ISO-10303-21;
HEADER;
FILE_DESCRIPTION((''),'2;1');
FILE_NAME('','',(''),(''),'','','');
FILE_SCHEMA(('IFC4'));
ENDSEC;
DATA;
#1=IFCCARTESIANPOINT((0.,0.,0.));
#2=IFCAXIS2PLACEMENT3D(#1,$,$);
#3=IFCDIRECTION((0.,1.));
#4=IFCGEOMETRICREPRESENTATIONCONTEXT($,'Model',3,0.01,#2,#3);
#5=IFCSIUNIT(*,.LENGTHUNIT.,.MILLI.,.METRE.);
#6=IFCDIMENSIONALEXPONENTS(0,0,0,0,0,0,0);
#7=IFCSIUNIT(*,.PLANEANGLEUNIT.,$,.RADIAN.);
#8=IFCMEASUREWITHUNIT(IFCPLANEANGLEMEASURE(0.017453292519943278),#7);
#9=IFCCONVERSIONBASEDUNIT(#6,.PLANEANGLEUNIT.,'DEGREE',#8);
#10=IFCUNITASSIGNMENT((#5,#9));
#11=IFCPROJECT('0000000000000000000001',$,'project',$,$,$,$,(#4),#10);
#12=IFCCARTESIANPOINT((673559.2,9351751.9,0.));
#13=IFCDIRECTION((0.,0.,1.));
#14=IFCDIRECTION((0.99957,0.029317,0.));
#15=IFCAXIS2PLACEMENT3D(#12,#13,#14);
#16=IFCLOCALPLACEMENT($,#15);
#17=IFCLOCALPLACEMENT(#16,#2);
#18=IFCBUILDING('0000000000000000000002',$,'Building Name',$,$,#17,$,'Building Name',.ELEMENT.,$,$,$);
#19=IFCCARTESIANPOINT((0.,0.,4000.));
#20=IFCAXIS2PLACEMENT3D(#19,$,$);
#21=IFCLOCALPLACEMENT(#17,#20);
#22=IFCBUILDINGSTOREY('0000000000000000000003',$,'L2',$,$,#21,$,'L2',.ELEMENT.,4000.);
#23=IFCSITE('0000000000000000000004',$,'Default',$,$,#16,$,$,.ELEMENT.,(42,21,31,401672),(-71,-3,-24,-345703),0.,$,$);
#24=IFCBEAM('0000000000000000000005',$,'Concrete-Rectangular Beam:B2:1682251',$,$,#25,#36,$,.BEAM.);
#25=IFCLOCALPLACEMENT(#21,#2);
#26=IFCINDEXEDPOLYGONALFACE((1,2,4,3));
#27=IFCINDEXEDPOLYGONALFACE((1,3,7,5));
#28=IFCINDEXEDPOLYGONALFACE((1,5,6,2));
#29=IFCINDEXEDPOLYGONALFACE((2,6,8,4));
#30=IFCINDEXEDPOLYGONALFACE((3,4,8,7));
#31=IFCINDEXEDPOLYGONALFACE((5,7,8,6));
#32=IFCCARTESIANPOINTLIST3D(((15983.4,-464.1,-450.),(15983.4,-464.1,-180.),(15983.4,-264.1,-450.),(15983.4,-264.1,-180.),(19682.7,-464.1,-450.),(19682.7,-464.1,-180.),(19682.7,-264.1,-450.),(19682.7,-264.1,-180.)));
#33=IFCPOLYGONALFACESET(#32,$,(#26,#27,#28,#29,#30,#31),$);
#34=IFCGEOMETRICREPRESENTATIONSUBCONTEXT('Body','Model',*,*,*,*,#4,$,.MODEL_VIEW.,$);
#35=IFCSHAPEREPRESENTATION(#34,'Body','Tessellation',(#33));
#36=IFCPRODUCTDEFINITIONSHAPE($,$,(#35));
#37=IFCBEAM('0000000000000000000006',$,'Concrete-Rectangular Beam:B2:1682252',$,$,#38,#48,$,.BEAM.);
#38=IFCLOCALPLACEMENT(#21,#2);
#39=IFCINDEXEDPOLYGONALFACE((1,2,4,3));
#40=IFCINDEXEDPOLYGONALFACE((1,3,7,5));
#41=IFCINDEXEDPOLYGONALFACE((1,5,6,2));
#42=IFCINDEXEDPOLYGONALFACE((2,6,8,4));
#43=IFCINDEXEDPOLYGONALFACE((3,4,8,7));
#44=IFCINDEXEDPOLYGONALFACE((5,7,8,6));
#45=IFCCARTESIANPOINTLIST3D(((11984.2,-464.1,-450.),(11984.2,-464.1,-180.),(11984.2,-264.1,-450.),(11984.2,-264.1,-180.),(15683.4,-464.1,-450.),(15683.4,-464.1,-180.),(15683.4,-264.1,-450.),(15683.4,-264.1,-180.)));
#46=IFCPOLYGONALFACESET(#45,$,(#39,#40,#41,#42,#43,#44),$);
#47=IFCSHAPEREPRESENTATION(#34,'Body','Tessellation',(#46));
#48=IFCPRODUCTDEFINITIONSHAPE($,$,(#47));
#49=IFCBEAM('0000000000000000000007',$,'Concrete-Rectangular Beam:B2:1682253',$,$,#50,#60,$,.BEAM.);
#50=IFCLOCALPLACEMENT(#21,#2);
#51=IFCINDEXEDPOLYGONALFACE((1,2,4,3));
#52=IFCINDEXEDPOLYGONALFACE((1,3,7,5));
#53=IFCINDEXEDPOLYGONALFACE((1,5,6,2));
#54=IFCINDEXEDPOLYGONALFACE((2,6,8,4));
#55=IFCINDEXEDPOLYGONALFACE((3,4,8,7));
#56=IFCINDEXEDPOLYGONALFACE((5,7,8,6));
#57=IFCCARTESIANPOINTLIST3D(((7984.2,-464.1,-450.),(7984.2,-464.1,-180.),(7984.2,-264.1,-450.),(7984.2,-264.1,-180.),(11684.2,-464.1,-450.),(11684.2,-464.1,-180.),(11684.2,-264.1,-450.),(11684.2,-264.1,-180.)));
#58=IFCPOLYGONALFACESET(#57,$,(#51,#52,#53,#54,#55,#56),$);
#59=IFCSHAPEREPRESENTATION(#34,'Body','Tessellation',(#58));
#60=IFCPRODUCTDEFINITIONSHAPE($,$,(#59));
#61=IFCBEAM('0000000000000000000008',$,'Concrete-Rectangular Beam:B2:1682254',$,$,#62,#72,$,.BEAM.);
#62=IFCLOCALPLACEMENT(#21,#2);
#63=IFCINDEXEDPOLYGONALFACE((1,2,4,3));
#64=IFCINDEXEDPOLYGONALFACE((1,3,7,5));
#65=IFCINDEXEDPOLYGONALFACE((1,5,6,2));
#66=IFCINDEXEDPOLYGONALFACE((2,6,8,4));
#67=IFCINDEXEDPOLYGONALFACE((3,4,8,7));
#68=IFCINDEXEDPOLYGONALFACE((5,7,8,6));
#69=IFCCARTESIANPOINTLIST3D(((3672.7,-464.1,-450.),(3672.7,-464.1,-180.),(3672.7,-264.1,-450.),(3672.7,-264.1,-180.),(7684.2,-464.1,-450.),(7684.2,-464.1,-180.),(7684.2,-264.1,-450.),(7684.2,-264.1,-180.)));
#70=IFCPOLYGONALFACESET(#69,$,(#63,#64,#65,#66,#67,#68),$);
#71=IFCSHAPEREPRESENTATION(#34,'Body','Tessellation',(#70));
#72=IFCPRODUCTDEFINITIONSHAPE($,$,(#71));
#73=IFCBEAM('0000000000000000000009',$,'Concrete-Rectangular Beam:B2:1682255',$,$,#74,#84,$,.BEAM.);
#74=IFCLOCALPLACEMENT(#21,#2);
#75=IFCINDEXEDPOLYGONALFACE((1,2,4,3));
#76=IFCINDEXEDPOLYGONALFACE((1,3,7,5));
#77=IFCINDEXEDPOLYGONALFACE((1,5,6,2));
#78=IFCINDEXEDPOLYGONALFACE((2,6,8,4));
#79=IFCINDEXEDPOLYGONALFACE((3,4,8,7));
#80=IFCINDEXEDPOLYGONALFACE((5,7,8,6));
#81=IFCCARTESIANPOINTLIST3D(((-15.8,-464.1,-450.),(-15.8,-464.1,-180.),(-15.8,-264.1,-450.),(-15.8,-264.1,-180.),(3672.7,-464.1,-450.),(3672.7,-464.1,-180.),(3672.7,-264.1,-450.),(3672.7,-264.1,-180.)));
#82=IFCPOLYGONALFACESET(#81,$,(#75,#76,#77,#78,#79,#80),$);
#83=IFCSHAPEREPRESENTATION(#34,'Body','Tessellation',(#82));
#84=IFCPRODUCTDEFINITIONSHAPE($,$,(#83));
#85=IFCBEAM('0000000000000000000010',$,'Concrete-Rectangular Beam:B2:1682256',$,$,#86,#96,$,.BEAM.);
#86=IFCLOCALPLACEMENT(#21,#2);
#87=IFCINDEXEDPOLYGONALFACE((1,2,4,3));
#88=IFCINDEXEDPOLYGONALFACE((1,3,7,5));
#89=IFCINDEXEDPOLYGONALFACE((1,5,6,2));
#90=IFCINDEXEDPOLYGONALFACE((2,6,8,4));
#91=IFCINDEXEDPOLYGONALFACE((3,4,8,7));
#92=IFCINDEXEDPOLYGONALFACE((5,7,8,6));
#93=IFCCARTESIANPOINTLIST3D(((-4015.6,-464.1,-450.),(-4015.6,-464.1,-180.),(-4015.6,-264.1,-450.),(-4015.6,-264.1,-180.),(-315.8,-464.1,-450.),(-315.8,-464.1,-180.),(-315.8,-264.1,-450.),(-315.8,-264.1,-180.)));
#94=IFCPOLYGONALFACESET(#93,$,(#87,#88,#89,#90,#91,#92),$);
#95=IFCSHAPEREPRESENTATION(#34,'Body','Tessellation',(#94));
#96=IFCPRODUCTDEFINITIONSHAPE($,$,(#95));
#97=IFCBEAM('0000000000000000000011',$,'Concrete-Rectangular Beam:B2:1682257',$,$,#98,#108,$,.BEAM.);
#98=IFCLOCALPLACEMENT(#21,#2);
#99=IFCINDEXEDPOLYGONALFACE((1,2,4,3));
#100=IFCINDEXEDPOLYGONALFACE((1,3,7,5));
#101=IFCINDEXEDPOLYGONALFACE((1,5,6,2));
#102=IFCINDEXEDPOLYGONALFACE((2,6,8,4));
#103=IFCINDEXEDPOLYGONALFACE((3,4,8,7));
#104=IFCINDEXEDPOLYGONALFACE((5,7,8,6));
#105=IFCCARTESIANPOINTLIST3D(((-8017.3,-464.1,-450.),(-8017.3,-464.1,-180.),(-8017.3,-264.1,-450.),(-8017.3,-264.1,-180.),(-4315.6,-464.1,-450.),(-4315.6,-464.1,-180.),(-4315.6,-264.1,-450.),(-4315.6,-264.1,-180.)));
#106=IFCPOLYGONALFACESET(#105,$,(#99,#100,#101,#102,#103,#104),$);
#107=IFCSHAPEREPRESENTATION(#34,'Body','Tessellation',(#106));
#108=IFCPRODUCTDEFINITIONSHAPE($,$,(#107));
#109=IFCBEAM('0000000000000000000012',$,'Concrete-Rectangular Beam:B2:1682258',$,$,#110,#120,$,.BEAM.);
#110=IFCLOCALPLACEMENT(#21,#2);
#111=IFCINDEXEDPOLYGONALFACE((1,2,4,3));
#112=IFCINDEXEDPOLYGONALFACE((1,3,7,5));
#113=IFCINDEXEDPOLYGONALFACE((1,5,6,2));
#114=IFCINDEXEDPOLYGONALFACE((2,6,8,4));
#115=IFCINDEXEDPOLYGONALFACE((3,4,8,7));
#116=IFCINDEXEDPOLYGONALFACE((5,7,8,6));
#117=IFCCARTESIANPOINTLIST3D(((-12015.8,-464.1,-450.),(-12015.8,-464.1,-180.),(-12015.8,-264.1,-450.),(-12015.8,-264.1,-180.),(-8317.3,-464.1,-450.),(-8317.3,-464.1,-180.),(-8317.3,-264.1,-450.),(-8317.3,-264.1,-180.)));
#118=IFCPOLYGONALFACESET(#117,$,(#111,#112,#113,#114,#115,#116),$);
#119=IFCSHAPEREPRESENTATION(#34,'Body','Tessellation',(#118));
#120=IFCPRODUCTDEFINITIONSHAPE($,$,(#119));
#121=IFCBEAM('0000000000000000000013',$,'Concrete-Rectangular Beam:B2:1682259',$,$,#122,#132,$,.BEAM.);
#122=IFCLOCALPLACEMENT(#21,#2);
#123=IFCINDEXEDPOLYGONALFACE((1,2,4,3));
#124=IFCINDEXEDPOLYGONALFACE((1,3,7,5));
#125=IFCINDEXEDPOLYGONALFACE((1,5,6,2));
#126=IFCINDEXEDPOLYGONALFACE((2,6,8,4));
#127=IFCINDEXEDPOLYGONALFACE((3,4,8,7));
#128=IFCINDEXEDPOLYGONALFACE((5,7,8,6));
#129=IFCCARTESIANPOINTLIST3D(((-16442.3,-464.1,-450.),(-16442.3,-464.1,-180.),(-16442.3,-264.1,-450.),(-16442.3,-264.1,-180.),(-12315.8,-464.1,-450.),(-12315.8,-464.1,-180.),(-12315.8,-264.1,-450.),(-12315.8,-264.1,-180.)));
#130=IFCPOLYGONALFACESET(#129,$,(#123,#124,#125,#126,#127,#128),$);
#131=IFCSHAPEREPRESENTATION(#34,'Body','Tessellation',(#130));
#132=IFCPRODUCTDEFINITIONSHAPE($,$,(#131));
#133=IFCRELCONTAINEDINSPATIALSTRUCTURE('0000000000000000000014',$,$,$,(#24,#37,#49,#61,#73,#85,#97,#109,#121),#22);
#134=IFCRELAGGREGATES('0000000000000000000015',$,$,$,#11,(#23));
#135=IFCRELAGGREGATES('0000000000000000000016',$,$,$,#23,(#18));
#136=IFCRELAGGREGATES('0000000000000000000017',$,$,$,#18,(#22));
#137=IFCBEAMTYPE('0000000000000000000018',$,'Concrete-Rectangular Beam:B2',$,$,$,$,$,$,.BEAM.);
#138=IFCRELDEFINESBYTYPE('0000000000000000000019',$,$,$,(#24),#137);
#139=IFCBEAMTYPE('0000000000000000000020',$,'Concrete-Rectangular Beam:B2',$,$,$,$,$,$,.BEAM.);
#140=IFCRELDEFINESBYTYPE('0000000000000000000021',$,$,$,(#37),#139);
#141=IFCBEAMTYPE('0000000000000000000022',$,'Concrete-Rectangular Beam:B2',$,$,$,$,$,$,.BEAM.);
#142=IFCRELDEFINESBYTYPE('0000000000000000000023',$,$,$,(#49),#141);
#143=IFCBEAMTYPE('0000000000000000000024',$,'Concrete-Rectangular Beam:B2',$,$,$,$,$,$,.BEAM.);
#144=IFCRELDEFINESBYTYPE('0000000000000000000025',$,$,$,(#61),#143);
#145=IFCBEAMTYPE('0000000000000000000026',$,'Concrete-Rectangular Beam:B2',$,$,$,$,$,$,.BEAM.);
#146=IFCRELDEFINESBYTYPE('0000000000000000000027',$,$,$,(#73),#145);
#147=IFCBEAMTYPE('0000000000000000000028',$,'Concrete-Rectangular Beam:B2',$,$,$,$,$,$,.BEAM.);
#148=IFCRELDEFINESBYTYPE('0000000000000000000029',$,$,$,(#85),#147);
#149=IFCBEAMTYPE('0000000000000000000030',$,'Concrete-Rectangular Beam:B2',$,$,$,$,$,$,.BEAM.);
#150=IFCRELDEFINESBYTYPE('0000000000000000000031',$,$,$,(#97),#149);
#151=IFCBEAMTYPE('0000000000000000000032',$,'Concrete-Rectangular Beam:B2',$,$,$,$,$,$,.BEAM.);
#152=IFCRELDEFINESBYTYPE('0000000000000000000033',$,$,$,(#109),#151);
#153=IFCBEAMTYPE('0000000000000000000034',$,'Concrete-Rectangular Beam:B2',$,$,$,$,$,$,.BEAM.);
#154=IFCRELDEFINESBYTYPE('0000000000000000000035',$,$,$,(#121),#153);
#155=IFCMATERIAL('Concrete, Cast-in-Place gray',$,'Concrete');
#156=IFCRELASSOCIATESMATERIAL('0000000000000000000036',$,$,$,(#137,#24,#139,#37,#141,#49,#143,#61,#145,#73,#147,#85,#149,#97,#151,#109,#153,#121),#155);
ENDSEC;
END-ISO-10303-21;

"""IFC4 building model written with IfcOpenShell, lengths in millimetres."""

from ifc_helpers import new_model, entity, si_unit, converted_unit, direction, frame, origin, place, context, subcontext, project, spatial, indexed_curve, outline, extrude, source, transform, mapped, material, type_object, type_shapes, element, save


model = new_model("IFC4")

# Units and contexts
model_context = context("Model", 3, precision=0.01, world=origin(), true_north=direction((0.0, 1.0)))
body_context = subcontext(model_context, "Body", "Model", "MODEL_VIEW")
ifc_project = project(units=[si_unit("LENGTHUNIT", "METRE", prefix="MILLI"), converted_unit("PLANEANGLEUNIT", "DEGREE", entity("IfcPlaneAngleMeasure", 0.017453292519943278), si_unit("PLANEANGLEUNIT", "RADIAN"), dimensions=[0, 0, 0, 0, 0, 0, 0])], contexts=[model_context])

# Site, building, storey
site_placement = place(None, frame((673559.2, 9351751.9, 0.0), z_axis=(0.0, 0.0, 1.0), x_axis=(0.99957, 0.029317, 0.0)))
site = spatial("IfcSite", under=ifc_project, at=site_placement, Name="Default", CompositionType="ELEMENT", RefLatitude=(42, 21, 31, 401672), RefLongitude=(-71, -3, -24, -345703), RefElevation=0.0)
building_placement = place(site_placement, origin())
building = spatial("IfcBuilding", under=site, at=building_placement, Name="Building Name", LongName="Building Name", CompositionType="ELEMENT")
storey_placement = place(building_placement, frame((0.0, 0.0, 4000.0)))
storey = spatial("IfcBuildingStorey", under=building, at=storey_placement, Name="L2", LongName="L2", CompositionType="ELEMENT", Elevation=4000.0)

# Beams
ifc_material = material(Name="Concrete, Cast-in-Place gray", Category="Concrete")
beam_type_1 = type_object("IfcBeamType", Name="Concrete-Rectangular Beam:B2", PredefinedType="BEAM", material=ifc_material)
shared_shape_1 = source(origin(), body_context, "Body", "SweptSolid", [
    extrude(outline(indexed_curve([(-135.0, -100.0), (135.0, -100.0), (135.0, 100.0), (-135.0, 100.0), (-135.0, -100.0)], self_intersect=False)), frame((19682.7, -364.1, 3685.0), z_axis=(-1.0, 0.0, 0.0), x_axis=(0.0, 0.0, -1.0)), (0.0, 0.0, 1.0), 3699.3),
])
type_shapes(beam_type_1, [shared_shape_1])
beam_1_placement = place(storey_placement, frame((0.0, 0.0, -4000.0)))
element("IfcBeam", 1, at=beam_1_placement, inside=storey, type_object=beam_type_1, material=ifc_material, Name="Concrete-Rectangular Beam:B2:1682251", PredefinedType="BEAM", context=body_context, shape_type="MappedRepresentation", body=[
    mapped(shared_shape_1, transform((0.0, 0.0, 0.0), scale=1.0)),
])
beam_type_2 = type_object("IfcBeamType", Name="Concrete-Rectangular Beam:B2", PredefinedType="BEAM", material=ifc_material)
shared_shape_2 = source(origin(), body_context, "Body", "SweptSolid", [
    extrude(outline(indexed_curve([(-135.0, -100.0), (135.0, -100.0), (135.0, 100.0), (-135.0, 100.0), (-135.0, -100.0)], self_intersect=False)), frame((11984.2, -364.1, 3685.0), z_axis=(1.0, 0.0, 0.0), x_axis=(0.0, 0.0, -1.0)), (0.0, 0.0, 1.0), 3699.3),
])
type_shapes(beam_type_2, [shared_shape_2])
beam_2_placement = place(storey_placement, frame((0.0, 0.0, -4000.0)))
element("IfcBeam", 2, at=beam_2_placement, inside=storey, type_object=beam_type_2, material=ifc_material, Name="Concrete-Rectangular Beam:B2:1682252", PredefinedType="BEAM", context=body_context, shape_type="MappedRepresentation", body=[
    mapped(shared_shape_2, transform((0.0, 0.0, 0.0), scale=1.0)),
])
beam_type_3 = type_object("IfcBeamType", Name="Concrete-Rectangular Beam:B2", PredefinedType="BEAM", material=ifc_material)
shared_shape_3 = source(origin(), body_context, "Body", "SweptSolid", [
    extrude(outline(indexed_curve([(-135.0, -100.0), (135.0, -100.0), (135.0, 100.0), (-135.0, 100.0), (-135.0, -100.0)], self_intersect=False)), frame((11684.2, -364.1, 3685.0), z_axis=(-1.0, 0.0, 0.0), x_axis=(0.0, 0.0, -1.0)), (0.0, 0.0, 1.0), 3700.0),
])
type_shapes(beam_type_3, [shared_shape_3])
beam_3_placement = place(storey_placement, frame((0.0, 0.0, -4000.0)))
element("IfcBeam", 3, at=beam_3_placement, inside=storey, type_object=beam_type_3, material=ifc_material, Name="Concrete-Rectangular Beam:B2:1682253", PredefinedType="BEAM", context=body_context, shape_type="MappedRepresentation", body=[
    mapped(shared_shape_3, transform((0.0, 0.0, 0.0), scale=1.0)),
])
beam_type_4 = type_object("IfcBeamType", Name="Concrete-Rectangular Beam:B2", PredefinedType="BEAM", material=ifc_material)
shared_shape_4 = source(origin(), body_context, "Body", "SweptSolid", [
    extrude(outline(indexed_curve([(-135.0, -100.0), (135.0, -100.0), (135.0, 100.0), (-135.0, 100.0), (-135.0, -100.0)], self_intersect=False)), frame((7684.2, -364.1, 3685.0), z_axis=(-1.0, 0.0, 0.0), x_axis=(0.0, 0.0, -1.0)), (0.0, 0.0, 1.0), 4011.4),
])
type_shapes(beam_type_4, [shared_shape_4])
beam_4_placement = place(storey_placement, frame((0.0, 0.0, -4000.0)))
element("IfcBeam", 4, at=beam_4_placement, inside=storey, type_object=beam_type_4, material=ifc_material, Name="Concrete-Rectangular Beam:B2:1682254", PredefinedType="BEAM", context=body_context, shape_type="MappedRepresentation", body=[
    mapped(shared_shape_4, transform((0.0, 0.0, 0.0), scale=1.0)),
])
beam_type_5 = type_object("IfcBeamType", Name="Concrete-Rectangular Beam:B2", PredefinedType="BEAM", material=ifc_material)
shared_shape_5 = source(origin(), body_context, "Body", "SweptSolid", [
    extrude(outline(indexed_curve([(-135.0, -100.0), (135.0, -100.0), (135.0, 100.0), (-135.0, 100.0), (-135.0, -100.0)], self_intersect=False)), frame((3672.7, -364.1, 3685.0), z_axis=(-1.0, 0.0, 0.0), x_axis=(0.0, 0.0, -1.0)), (0.0, 0.0, 1.0), 3688.6),
])
type_shapes(beam_type_5, [shared_shape_5])
beam_5_placement = place(storey_placement, frame((0.0, 0.0, -4000.0)))
element("IfcBeam", 5, at=beam_5_placement, inside=storey, type_object=beam_type_5, material=ifc_material, Name="Concrete-Rectangular Beam:B2:1682255", PredefinedType="BEAM", context=body_context, shape_type="MappedRepresentation", body=[
    mapped(shared_shape_5, transform((0.0, 0.0, 0.0), scale=1.0)),
])
beam_type_6 = type_object("IfcBeamType", Name="Concrete-Rectangular Beam:B2", PredefinedType="BEAM", material=ifc_material)
shared_shape_6 = source(origin(), body_context, "Body", "SweptSolid", [
    extrude(outline(indexed_curve([(-135.0, -100.0), (135.0, -100.0), (135.0, 100.0), (-135.0, 100.0), (-135.0, -100.0)], self_intersect=False)), frame((-315.8, -364.1, 3685.0), z_axis=(-1.0, 0.0, 0.0), x_axis=(0.0, 0.0, -1.0)), (0.0, 0.0, 1.0), 3699.7),
])
type_shapes(beam_type_6, [shared_shape_6])
beam_6_placement = place(storey_placement, frame((0.0, 0.0, -4000.0)))
element("IfcBeam", 6, at=beam_6_placement, inside=storey, type_object=beam_type_6, material=ifc_material, Name="Concrete-Rectangular Beam:B2:1682256", PredefinedType="BEAM", context=body_context, shape_type="MappedRepresentation", body=[
    mapped(shared_shape_6, transform((0.0, 0.0, 0.0), scale=1.0)),
])
beam_type_7 = type_object("IfcBeamType", Name="Concrete-Rectangular Beam:B2", PredefinedType="BEAM", material=ifc_material)
shared_shape_7 = source(origin(), body_context, "Body", "SweptSolid", [
    extrude(outline(indexed_curve([(-135.0, -100.0), (135.0, -100.0), (135.0, 100.0), (-135.0, 100.0), (-135.0, -100.0)], self_intersect=False)), frame((-4315.6, -364.1, 3685.0), z_axis=(-1.0, 0.0, 0.0), x_axis=(0.0, 0.0, -1.0)), (0.0, 0.0, 1.0), 3701.8),
])
type_shapes(beam_type_7, [shared_shape_7])
beam_7_placement = place(storey_placement, frame((0.0, 0.0, -4000.0)))
element("IfcBeam", 7, at=beam_7_placement, inside=storey, type_object=beam_type_7, material=ifc_material, Name="Concrete-Rectangular Beam:B2:1682257", PredefinedType="BEAM", context=body_context, shape_type="MappedRepresentation", body=[
    mapped(shared_shape_7, transform((0.0, 0.0, 0.0), scale=1.0)),
])
beam_type_8 = type_object("IfcBeamType", Name="Concrete-Rectangular Beam:B2", PredefinedType="BEAM", material=ifc_material)
shared_shape_8 = source(origin(), body_context, "Body", "SweptSolid", [
    extrude(outline(indexed_curve([(-135.0, -100.0), (135.0, -100.0), (135.0, 100.0), (-135.0, 100.0), (-135.0, -100.0)], self_intersect=False)), frame((-8317.3, -364.1, 3685.0), z_axis=(-1.0, 0.0, 0.0), x_axis=(0.0, 0.0, -1.0)), (0.0, 0.0, 1.0), 3698.5),
])
type_shapes(beam_type_8, [shared_shape_8])
beam_8_placement = place(storey_placement, frame((0.0, 0.0, -4000.0)))
element("IfcBeam", 8, at=beam_8_placement, inside=storey, type_object=beam_type_8, material=ifc_material, Name="Concrete-Rectangular Beam:B2:1682258", PredefinedType="BEAM", context=body_context, shape_type="MappedRepresentation", body=[
    mapped(shared_shape_8, transform((0.0, 0.0, 0.0), scale=1.0)),
])
beam_type_9 = type_object("IfcBeamType", Name="Concrete-Rectangular Beam:B2", PredefinedType="BEAM", material=ifc_material)
shared_shape_9 = source(origin(), body_context, "Body", "SweptSolid", [
    extrude(outline(indexed_curve([(-135.0, -100.0), (135.0, -100.0), (135.0, 100.0), (-135.0, 100.0), (-135.0, -100.0)], self_intersect=False)), frame((-12315.8, -364.1, 3685.0), z_axis=(-1.0, 0.0, 0.0), x_axis=(0.0, 0.0, -1.0)), (0.0, 0.0, 1.0), 4126.5),
])
type_shapes(beam_type_9, [shared_shape_9])
beam_9_placement = place(storey_placement, frame((0.0, 0.0, -4000.0)))
element("IfcBeam", 9, at=beam_9_placement, inside=storey, type_object=beam_type_9, material=ifc_material, Name="Concrete-Rectangular Beam:B2:1682259", PredefinedType="BEAM", context=body_context, shape_type="MappedRepresentation", body=[
    mapped(shared_shape_9, transform((0.0, 0.0, 0.0), scale=1.0)),
])

save(model, "model.ifc")
